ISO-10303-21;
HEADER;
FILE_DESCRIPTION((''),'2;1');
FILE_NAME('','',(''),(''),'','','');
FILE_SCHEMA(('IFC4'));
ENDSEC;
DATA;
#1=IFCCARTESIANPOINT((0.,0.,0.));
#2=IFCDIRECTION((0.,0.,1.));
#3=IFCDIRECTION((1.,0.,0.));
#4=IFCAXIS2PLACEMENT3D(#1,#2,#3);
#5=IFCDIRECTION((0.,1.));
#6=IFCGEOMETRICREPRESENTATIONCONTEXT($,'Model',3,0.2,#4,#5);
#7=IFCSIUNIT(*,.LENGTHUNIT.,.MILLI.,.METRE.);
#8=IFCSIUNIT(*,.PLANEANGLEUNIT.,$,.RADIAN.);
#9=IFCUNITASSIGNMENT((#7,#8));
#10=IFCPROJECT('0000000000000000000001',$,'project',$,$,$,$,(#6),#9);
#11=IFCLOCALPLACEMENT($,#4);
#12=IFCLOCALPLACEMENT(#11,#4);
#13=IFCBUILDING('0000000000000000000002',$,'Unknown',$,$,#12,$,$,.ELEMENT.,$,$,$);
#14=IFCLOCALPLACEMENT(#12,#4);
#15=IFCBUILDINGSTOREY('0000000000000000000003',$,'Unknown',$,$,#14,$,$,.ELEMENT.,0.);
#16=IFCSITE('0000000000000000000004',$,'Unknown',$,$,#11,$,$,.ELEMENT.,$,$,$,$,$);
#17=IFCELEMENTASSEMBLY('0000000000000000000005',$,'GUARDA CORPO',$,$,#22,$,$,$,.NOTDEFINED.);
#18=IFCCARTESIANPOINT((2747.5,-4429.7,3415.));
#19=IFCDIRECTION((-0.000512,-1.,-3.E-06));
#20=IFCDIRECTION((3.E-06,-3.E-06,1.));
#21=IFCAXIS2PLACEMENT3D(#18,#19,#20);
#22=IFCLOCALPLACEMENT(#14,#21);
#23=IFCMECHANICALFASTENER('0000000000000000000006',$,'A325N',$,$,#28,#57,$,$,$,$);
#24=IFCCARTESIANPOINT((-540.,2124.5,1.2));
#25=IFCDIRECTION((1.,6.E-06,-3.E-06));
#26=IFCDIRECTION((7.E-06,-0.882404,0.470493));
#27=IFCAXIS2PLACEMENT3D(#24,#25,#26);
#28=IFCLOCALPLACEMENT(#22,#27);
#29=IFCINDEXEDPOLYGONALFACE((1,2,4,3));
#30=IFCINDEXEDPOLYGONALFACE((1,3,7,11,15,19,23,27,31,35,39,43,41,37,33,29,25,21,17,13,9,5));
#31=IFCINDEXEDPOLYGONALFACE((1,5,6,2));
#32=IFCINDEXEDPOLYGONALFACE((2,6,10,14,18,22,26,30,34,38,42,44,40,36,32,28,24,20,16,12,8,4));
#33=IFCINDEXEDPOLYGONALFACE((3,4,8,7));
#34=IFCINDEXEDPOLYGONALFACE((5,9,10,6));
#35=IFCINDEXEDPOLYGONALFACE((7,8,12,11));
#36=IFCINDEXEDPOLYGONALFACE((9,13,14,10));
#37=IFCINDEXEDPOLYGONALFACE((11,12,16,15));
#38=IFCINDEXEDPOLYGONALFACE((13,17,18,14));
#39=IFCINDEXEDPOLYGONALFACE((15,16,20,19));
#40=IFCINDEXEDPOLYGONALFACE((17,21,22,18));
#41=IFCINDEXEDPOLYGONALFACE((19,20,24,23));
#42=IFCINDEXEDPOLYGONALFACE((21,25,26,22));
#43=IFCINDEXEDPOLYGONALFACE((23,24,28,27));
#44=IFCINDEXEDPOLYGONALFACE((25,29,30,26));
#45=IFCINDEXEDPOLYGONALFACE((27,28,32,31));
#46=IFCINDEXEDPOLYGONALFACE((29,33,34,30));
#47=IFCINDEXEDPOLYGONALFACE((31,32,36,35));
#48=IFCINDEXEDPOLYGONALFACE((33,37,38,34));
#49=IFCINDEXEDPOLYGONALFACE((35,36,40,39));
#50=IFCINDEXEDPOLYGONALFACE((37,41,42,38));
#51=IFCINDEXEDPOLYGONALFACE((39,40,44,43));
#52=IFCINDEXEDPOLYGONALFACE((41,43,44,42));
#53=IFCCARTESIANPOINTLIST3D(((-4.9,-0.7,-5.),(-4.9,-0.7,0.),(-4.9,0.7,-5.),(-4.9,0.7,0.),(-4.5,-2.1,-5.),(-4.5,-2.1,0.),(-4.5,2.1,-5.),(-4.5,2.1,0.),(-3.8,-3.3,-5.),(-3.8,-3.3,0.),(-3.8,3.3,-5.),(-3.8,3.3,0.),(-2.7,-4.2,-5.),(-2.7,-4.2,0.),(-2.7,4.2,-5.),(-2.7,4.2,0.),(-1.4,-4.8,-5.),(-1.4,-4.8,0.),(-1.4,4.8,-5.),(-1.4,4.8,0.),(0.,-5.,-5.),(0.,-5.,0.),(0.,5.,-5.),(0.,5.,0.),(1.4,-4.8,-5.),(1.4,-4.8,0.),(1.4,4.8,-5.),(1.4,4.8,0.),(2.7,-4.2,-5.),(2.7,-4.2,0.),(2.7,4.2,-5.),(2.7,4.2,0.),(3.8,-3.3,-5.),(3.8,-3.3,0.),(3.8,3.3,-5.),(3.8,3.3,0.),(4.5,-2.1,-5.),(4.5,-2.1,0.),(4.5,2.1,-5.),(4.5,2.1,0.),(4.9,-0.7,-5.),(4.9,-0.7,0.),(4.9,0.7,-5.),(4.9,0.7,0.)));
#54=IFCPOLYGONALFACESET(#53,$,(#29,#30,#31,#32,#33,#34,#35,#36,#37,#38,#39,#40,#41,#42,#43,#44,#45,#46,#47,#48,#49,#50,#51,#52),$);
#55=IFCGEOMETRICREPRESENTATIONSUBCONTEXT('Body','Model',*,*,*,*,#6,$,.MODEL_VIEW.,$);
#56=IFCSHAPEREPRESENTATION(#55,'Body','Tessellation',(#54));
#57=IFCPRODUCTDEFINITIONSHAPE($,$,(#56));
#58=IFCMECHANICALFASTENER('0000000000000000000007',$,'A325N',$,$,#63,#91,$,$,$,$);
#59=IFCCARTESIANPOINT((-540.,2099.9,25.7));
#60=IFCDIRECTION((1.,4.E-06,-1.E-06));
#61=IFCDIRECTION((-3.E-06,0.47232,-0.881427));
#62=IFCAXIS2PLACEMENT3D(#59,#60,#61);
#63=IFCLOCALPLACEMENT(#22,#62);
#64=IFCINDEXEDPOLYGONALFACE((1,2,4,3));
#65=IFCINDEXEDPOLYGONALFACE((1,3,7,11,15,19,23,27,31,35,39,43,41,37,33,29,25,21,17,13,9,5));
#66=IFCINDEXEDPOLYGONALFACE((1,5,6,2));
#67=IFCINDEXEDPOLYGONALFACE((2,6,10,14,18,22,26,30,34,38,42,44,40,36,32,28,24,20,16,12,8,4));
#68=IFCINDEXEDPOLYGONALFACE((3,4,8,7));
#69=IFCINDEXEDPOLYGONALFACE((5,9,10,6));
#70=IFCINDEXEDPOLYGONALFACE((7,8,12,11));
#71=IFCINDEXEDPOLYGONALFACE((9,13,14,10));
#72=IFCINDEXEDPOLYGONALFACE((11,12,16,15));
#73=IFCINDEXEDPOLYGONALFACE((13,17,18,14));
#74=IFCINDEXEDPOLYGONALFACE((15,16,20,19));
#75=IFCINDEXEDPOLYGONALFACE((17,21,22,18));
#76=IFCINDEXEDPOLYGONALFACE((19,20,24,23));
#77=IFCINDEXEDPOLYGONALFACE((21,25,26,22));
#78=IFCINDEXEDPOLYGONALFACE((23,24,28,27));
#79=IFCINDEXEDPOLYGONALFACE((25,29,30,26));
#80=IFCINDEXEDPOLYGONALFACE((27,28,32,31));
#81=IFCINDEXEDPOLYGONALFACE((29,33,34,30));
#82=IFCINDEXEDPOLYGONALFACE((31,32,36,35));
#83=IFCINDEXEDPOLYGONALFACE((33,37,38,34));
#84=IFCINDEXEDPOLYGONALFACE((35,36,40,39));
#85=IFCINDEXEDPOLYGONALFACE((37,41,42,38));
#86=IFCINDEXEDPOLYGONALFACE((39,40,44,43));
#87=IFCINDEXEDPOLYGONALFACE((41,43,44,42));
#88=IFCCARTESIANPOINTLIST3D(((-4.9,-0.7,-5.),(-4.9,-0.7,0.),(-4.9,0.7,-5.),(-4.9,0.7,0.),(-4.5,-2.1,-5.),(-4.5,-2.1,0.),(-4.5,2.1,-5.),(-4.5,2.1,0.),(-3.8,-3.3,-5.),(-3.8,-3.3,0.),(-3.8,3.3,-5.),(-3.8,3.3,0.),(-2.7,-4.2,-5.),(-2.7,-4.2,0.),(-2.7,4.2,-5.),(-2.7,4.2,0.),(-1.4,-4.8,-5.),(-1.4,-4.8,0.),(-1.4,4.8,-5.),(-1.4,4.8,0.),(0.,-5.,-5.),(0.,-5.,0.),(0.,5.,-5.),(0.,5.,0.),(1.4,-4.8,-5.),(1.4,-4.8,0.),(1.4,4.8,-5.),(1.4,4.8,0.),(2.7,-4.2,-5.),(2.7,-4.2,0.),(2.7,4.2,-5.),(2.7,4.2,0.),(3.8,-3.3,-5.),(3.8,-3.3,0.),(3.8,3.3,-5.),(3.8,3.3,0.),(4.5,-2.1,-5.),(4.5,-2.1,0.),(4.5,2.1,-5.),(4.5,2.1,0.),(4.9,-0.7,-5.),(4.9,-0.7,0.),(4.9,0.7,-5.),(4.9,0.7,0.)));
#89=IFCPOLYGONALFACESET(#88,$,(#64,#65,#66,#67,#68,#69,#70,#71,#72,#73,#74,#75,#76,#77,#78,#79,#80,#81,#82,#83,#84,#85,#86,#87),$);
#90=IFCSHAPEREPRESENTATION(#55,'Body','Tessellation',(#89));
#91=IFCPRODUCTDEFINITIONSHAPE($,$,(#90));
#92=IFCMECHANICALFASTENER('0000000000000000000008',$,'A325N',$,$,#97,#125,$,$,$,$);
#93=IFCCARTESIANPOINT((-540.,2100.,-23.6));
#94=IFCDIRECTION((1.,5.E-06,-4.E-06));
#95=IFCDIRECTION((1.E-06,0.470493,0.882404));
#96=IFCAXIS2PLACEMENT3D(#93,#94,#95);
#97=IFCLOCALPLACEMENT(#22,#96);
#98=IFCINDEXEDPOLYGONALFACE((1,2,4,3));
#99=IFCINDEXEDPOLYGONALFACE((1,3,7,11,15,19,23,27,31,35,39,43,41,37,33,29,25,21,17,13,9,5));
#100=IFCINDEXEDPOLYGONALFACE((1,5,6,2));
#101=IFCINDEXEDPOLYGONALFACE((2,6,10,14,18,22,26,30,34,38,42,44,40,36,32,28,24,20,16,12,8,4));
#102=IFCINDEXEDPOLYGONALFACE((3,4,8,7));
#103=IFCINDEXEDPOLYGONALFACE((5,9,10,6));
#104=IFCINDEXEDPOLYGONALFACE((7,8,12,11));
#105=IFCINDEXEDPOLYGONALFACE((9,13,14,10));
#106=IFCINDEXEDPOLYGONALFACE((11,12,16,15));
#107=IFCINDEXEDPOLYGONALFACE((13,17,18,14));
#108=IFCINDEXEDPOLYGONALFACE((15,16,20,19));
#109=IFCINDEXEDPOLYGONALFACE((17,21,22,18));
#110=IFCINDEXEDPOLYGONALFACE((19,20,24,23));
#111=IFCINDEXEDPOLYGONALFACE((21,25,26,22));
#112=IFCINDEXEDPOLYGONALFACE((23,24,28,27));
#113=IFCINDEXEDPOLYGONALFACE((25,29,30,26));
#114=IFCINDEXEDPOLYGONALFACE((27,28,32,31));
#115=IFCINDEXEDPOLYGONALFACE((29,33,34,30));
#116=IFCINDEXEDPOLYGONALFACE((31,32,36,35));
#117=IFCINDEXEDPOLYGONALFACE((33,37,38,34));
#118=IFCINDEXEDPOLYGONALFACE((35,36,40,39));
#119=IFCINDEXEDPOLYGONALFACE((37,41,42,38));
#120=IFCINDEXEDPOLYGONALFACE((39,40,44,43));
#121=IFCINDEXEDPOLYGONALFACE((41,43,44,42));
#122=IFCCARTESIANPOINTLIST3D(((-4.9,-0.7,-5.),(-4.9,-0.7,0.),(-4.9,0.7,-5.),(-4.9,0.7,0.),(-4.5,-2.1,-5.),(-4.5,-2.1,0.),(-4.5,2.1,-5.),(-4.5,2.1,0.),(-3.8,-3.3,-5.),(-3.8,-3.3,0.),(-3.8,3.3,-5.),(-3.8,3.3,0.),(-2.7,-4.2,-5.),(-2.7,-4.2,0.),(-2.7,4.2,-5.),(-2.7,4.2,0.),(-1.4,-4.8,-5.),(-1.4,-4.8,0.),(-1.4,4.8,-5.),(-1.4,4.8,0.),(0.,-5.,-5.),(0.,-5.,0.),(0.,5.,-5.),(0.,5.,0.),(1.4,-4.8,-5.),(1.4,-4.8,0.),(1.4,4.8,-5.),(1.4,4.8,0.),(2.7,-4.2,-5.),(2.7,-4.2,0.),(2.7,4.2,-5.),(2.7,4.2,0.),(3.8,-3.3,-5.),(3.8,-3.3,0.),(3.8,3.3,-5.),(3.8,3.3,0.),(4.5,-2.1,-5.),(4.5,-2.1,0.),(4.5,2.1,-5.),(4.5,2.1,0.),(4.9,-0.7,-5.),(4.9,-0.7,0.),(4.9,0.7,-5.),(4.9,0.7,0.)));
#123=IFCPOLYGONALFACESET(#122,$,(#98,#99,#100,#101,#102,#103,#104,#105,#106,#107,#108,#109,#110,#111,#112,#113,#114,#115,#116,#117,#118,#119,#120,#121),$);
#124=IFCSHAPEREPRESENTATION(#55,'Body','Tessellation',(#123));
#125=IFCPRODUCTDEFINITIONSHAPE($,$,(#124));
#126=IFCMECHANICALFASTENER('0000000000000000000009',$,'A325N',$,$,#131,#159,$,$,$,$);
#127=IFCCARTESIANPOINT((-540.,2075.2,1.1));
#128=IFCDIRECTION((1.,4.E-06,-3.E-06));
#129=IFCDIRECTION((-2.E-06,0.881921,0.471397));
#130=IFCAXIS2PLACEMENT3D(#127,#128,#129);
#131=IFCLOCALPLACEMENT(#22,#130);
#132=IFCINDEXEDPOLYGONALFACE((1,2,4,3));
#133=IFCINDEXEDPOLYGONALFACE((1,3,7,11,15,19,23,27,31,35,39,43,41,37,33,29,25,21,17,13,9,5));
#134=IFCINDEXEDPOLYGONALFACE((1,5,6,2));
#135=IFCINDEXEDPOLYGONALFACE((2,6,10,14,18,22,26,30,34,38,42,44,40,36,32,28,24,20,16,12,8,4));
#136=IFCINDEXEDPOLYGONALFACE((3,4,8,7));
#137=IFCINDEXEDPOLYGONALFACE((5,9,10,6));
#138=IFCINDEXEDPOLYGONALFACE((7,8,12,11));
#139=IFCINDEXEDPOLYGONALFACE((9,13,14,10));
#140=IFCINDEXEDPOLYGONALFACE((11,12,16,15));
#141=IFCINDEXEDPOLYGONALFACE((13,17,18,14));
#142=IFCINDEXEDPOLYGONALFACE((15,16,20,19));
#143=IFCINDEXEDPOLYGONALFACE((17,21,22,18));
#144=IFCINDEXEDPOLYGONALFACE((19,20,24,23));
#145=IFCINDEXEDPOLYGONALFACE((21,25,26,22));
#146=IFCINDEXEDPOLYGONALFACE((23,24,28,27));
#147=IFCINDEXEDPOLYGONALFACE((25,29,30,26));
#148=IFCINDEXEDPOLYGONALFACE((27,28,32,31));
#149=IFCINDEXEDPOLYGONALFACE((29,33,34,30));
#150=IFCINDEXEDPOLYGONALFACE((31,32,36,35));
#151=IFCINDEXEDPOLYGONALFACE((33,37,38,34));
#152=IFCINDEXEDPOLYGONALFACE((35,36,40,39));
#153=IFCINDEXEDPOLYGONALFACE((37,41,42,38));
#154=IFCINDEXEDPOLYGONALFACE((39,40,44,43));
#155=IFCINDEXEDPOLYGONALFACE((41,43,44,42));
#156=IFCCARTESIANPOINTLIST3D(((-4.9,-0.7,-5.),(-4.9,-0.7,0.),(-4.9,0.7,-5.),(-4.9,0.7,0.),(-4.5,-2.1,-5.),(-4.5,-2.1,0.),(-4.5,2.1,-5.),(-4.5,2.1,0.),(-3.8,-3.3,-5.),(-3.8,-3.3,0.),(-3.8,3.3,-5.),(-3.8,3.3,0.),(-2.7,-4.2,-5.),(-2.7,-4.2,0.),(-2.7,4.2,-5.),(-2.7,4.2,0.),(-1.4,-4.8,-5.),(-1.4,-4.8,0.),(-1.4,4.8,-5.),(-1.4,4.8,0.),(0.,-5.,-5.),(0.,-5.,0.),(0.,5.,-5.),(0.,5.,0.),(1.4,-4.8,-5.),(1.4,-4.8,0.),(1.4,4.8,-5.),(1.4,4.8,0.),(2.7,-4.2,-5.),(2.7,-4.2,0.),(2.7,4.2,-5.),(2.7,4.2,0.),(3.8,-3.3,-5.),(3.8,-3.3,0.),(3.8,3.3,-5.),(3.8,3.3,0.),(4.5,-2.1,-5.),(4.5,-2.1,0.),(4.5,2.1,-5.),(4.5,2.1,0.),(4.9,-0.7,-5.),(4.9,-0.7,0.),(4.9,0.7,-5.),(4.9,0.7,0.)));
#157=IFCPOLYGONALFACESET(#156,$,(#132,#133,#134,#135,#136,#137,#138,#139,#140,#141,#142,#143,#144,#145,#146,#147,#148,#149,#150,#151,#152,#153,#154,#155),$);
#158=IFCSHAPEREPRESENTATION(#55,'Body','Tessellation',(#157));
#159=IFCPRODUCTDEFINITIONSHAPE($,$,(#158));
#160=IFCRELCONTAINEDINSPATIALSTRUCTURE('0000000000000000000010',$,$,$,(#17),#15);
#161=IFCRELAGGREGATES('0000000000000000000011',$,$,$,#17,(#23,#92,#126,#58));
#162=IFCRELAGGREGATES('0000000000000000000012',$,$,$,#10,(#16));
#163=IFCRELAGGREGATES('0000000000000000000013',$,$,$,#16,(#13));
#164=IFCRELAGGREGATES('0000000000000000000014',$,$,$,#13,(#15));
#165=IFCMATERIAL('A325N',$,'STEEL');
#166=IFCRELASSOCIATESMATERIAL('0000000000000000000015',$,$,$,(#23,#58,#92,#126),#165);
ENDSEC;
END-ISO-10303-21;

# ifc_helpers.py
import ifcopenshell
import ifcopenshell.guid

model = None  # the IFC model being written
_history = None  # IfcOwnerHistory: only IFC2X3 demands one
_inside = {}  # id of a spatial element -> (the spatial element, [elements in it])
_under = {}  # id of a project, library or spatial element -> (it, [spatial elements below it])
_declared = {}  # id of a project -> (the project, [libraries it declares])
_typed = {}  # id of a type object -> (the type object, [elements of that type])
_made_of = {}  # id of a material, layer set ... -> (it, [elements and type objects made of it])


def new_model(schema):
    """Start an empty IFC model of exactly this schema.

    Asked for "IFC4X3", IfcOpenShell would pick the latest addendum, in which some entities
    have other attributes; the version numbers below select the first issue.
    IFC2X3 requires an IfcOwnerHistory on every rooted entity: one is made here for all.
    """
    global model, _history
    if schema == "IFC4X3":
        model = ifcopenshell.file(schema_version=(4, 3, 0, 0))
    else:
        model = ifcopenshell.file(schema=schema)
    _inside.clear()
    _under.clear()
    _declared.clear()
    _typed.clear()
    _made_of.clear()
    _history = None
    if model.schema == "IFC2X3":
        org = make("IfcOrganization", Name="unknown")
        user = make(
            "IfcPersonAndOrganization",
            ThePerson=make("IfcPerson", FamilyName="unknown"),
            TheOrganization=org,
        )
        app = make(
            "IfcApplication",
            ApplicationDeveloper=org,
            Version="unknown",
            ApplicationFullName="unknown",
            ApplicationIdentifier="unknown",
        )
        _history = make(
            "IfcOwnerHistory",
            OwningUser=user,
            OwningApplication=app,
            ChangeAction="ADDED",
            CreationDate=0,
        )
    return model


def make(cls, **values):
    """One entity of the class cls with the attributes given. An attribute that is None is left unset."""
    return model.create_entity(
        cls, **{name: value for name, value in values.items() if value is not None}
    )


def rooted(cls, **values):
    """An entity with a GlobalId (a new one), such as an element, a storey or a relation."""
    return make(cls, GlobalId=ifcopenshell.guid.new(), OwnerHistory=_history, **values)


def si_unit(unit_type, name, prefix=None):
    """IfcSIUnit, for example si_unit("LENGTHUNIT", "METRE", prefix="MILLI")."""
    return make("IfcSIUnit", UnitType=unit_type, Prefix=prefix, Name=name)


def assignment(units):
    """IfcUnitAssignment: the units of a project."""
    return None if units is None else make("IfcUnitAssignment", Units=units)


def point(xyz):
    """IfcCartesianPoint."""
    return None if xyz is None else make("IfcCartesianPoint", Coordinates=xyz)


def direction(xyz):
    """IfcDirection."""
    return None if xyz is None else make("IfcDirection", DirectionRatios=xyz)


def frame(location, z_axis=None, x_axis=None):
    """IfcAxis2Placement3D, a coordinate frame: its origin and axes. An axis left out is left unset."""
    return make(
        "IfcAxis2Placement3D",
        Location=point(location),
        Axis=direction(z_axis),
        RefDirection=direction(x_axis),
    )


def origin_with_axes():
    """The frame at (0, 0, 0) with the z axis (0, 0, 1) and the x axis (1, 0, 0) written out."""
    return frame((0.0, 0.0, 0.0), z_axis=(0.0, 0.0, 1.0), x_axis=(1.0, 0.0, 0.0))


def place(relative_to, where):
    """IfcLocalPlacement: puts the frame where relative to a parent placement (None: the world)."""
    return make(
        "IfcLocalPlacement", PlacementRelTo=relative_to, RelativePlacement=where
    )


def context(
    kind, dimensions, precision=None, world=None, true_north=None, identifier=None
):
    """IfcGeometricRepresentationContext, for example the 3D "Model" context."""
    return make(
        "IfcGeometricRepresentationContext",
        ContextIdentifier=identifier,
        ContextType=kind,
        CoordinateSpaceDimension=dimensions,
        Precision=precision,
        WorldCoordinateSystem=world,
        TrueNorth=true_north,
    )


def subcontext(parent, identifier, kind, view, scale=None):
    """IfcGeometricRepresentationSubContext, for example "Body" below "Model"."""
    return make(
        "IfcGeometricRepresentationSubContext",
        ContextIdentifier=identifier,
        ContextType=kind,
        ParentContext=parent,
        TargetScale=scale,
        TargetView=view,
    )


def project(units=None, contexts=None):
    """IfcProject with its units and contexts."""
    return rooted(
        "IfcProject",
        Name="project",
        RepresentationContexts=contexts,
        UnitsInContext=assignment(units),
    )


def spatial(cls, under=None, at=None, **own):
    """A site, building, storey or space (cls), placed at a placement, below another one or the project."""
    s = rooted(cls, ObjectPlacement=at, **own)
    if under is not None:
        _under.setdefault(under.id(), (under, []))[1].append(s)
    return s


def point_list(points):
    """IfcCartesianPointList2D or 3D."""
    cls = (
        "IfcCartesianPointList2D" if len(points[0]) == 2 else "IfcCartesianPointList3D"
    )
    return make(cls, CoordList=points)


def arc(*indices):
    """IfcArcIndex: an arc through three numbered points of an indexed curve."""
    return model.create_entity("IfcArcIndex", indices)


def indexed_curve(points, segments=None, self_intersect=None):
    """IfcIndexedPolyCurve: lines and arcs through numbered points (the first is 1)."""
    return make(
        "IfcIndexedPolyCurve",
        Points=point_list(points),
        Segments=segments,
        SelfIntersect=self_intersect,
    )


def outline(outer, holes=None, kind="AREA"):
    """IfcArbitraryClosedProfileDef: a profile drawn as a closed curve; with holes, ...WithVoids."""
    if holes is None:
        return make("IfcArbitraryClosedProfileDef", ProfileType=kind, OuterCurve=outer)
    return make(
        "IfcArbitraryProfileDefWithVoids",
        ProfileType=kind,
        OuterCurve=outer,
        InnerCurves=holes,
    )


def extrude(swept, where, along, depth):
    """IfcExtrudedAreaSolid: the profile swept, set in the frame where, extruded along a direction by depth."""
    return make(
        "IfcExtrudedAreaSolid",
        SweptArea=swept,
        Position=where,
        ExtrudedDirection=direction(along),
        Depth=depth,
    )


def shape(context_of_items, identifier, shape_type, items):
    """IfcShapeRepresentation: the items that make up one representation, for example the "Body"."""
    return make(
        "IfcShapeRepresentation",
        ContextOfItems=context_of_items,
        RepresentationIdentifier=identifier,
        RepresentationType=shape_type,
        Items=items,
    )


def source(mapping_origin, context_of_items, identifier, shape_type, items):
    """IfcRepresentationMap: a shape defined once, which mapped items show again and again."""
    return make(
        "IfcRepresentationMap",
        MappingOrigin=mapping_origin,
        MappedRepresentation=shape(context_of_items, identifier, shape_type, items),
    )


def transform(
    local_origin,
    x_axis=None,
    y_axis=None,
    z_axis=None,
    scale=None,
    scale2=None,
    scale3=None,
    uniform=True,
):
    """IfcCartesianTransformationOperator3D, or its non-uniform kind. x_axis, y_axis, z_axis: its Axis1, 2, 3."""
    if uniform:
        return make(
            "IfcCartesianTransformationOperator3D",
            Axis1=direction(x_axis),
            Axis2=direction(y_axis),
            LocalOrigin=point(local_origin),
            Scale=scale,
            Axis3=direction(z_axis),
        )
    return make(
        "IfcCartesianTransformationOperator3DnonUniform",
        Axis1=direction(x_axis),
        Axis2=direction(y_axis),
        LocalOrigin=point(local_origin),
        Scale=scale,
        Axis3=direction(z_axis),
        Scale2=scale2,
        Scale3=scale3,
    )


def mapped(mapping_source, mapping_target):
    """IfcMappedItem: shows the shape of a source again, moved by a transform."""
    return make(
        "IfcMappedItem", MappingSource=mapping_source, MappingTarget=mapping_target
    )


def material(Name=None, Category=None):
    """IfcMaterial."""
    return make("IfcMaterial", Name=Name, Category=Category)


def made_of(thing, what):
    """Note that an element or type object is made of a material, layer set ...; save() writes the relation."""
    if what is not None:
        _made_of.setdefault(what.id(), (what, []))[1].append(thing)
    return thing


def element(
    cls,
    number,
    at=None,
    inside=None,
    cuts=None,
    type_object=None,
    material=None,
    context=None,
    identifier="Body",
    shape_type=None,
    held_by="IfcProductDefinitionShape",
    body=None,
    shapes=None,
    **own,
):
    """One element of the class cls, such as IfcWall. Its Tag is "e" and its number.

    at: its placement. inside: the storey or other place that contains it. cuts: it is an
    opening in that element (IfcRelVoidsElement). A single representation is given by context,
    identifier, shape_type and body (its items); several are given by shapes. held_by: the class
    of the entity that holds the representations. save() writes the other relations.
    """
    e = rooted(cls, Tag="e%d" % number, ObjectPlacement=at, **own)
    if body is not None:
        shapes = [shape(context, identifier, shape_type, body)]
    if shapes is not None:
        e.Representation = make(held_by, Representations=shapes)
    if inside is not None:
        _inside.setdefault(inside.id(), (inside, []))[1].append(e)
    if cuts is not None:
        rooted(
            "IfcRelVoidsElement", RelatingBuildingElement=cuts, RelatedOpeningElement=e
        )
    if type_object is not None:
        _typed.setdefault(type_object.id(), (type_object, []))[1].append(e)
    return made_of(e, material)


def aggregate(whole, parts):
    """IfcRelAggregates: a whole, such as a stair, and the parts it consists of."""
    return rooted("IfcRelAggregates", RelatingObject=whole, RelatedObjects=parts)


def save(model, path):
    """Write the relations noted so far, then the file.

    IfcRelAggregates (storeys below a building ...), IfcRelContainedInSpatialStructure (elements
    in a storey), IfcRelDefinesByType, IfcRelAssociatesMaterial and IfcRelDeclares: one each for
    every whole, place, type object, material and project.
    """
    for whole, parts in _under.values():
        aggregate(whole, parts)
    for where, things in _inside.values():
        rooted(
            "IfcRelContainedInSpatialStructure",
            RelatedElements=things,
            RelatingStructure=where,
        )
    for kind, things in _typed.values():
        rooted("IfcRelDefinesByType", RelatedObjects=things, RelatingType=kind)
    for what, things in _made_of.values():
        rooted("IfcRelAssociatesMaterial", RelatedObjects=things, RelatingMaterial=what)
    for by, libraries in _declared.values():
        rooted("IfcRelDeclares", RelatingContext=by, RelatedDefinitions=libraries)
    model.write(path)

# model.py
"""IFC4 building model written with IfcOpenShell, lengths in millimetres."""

from ifc_helpers import new_model, si_unit, direction, frame, origin_with_axes, place, context, subcontext, project, spatial, arc, indexed_curve, outline, extrude, source, transform, mapped, material, element, aggregate, save


model = new_model("IFC4")

# Units and contexts
model_context = context("Model", 3, precision=0.2, world=origin_with_axes(), true_north=direction((0.0, 1.0)))
body_context = subcontext(model_context, "Body", "Model", "MODEL_VIEW")
ifc_project = project(units=[si_unit("LENGTHUNIT", "METRE", prefix="MILLI"), si_unit("PLANEANGLEUNIT", "RADIAN")], contexts=[model_context])

# Site, building, storey
site_placement = place(None, origin_with_axes())
site = spatial("IfcSite", under=ifc_project, at=site_placement, Name="Unknown", CompositionType="ELEMENT")
building_placement = place(site_placement, origin_with_axes())
building = spatial("IfcBuilding", under=site, at=building_placement, Name="Unknown", CompositionType="ELEMENT")
storey_placement = place(building_placement, origin_with_axes())
storey = spatial("IfcBuildingStorey", under=building, at=storey_placement, Name="Unknown", CompositionType="ELEMENT", Elevation=0.0)

# Element assembly
assembly_1_placement = place(storey_placement, frame((2747.5, -4429.7, 3415.0), z_axis=(-0.000512, -1.0, -0.000003), x_axis=(0.000003, -0.000003, 1.0)))
assembly_1 = element("IfcElementAssembly", 1, at=assembly_1_placement, inside=storey, Name="GUARDA CORPO", PredefinedType="NOTDEFINED")

# Shared definitions
ifc_material_1 = material(Name="A325N", Category="STEEL")

# Mechanical fasteners
shared_shape_1 = source(origin_with_axes(), body_context, "Body", "SweptSolid", [
    extrude(outline(indexed_curve([(5.0, 0.0), (0.0, 5.0), (-5.0, 0.0), (0.0, -5.0)], segments=[arc(1, 2, 3), arc(3, 4, 1)])), frame((0.0, 0.0, 0.0), z_axis=(0.0, 0.0, -1.0), x_axis=(0.0, 1.0, 0.0)), (0.0, 0.0, 1.0), 5.0),
])
mechanical_fastener_1_placement = place(assembly_1_placement, frame((-540.0, 2124.5, 1.2), z_axis=(1.0, 0.000006, -0.000003), x_axis=(0.000007, -0.882404, 0.470493)))
mechanical_fastener_1 = element("IfcMechanicalFastener", 2, at=mechanical_fastener_1_placement, material=ifc_material_1, Name="A325N", context=body_context, shape_type="MappedRepresentation", body=[
    mapped(shared_shape_1, transform((0.0, 0.0, 0.0))),
])
mechanical_fastener_2_placement = place(assembly_1_placement, frame((-540.0, 2099.9, 25.7), z_axis=(1.0, 0.000004, -0.000001), x_axis=(-0.000003, 0.47232, -0.881427)))
mechanical_fastener_2 = element("IfcMechanicalFastener", 3, at=mechanical_fastener_2_placement, material=ifc_material_1, Name="A325N", context=body_context, shape_type="MappedRepresentation", body=[
    mapped(shared_shape_1, transform((0.0, 0.0, 0.0))),
])
shared_shape_2 = source(origin_with_axes(), body_context, "Body", "SweptSolid", [
    extrude(outline(indexed_curve([(5.0, 0.0), (0.0, 5.0), (-5.0, 0.0), (0.0, -5.0)], segments=[arc(1, 2, 3), arc(3, 4, 1)])), frame((0.0, 0.0, 0.0), z_axis=(0.0, 0.0, -1.0), x_axis=(0.0, 1.0, 0.0)), (0.0, 0.0, 1.0), 5.0),
])
mechanical_fastener_3_placement = place(assembly_1_placement, frame((-540.0, 2100.0, -23.6), z_axis=(1.0, 0.000005, -0.000004), x_axis=(0.000001, 0.470493, 0.882404)))
mechanical_fastener_3 = element("IfcMechanicalFastener", 4, at=mechanical_fastener_3_placement, material=ifc_material_1, Name="A325N", context=body_context, shape_type="MappedRepresentation", body=[
    mapped(shared_shape_2, transform((0.0, 0.0, 0.0))),
])
mechanical_fastener_4_placement = place(assembly_1_placement, frame((-540.0, 2075.2, 1.1), z_axis=(1.0, 0.000004, -0.000003), x_axis=(-0.000002, 0.881921, 0.471397)))
mechanical_fastener_4 = element("IfcMechanicalFastener", 5, at=mechanical_fastener_4_placement, material=ifc_material_1, Name="A325N", context=body_context, shape_type="MappedRepresentation", body=[
    mapped(shared_shape_2, transform((0.0, 0.0, 0.0))),
])
aggregate(assembly_1, [mechanical_fastener_1, mechanical_fastener_3, mechanical_fastener_4, mechanical_fastener_2])

save(model, "model.ifc")
